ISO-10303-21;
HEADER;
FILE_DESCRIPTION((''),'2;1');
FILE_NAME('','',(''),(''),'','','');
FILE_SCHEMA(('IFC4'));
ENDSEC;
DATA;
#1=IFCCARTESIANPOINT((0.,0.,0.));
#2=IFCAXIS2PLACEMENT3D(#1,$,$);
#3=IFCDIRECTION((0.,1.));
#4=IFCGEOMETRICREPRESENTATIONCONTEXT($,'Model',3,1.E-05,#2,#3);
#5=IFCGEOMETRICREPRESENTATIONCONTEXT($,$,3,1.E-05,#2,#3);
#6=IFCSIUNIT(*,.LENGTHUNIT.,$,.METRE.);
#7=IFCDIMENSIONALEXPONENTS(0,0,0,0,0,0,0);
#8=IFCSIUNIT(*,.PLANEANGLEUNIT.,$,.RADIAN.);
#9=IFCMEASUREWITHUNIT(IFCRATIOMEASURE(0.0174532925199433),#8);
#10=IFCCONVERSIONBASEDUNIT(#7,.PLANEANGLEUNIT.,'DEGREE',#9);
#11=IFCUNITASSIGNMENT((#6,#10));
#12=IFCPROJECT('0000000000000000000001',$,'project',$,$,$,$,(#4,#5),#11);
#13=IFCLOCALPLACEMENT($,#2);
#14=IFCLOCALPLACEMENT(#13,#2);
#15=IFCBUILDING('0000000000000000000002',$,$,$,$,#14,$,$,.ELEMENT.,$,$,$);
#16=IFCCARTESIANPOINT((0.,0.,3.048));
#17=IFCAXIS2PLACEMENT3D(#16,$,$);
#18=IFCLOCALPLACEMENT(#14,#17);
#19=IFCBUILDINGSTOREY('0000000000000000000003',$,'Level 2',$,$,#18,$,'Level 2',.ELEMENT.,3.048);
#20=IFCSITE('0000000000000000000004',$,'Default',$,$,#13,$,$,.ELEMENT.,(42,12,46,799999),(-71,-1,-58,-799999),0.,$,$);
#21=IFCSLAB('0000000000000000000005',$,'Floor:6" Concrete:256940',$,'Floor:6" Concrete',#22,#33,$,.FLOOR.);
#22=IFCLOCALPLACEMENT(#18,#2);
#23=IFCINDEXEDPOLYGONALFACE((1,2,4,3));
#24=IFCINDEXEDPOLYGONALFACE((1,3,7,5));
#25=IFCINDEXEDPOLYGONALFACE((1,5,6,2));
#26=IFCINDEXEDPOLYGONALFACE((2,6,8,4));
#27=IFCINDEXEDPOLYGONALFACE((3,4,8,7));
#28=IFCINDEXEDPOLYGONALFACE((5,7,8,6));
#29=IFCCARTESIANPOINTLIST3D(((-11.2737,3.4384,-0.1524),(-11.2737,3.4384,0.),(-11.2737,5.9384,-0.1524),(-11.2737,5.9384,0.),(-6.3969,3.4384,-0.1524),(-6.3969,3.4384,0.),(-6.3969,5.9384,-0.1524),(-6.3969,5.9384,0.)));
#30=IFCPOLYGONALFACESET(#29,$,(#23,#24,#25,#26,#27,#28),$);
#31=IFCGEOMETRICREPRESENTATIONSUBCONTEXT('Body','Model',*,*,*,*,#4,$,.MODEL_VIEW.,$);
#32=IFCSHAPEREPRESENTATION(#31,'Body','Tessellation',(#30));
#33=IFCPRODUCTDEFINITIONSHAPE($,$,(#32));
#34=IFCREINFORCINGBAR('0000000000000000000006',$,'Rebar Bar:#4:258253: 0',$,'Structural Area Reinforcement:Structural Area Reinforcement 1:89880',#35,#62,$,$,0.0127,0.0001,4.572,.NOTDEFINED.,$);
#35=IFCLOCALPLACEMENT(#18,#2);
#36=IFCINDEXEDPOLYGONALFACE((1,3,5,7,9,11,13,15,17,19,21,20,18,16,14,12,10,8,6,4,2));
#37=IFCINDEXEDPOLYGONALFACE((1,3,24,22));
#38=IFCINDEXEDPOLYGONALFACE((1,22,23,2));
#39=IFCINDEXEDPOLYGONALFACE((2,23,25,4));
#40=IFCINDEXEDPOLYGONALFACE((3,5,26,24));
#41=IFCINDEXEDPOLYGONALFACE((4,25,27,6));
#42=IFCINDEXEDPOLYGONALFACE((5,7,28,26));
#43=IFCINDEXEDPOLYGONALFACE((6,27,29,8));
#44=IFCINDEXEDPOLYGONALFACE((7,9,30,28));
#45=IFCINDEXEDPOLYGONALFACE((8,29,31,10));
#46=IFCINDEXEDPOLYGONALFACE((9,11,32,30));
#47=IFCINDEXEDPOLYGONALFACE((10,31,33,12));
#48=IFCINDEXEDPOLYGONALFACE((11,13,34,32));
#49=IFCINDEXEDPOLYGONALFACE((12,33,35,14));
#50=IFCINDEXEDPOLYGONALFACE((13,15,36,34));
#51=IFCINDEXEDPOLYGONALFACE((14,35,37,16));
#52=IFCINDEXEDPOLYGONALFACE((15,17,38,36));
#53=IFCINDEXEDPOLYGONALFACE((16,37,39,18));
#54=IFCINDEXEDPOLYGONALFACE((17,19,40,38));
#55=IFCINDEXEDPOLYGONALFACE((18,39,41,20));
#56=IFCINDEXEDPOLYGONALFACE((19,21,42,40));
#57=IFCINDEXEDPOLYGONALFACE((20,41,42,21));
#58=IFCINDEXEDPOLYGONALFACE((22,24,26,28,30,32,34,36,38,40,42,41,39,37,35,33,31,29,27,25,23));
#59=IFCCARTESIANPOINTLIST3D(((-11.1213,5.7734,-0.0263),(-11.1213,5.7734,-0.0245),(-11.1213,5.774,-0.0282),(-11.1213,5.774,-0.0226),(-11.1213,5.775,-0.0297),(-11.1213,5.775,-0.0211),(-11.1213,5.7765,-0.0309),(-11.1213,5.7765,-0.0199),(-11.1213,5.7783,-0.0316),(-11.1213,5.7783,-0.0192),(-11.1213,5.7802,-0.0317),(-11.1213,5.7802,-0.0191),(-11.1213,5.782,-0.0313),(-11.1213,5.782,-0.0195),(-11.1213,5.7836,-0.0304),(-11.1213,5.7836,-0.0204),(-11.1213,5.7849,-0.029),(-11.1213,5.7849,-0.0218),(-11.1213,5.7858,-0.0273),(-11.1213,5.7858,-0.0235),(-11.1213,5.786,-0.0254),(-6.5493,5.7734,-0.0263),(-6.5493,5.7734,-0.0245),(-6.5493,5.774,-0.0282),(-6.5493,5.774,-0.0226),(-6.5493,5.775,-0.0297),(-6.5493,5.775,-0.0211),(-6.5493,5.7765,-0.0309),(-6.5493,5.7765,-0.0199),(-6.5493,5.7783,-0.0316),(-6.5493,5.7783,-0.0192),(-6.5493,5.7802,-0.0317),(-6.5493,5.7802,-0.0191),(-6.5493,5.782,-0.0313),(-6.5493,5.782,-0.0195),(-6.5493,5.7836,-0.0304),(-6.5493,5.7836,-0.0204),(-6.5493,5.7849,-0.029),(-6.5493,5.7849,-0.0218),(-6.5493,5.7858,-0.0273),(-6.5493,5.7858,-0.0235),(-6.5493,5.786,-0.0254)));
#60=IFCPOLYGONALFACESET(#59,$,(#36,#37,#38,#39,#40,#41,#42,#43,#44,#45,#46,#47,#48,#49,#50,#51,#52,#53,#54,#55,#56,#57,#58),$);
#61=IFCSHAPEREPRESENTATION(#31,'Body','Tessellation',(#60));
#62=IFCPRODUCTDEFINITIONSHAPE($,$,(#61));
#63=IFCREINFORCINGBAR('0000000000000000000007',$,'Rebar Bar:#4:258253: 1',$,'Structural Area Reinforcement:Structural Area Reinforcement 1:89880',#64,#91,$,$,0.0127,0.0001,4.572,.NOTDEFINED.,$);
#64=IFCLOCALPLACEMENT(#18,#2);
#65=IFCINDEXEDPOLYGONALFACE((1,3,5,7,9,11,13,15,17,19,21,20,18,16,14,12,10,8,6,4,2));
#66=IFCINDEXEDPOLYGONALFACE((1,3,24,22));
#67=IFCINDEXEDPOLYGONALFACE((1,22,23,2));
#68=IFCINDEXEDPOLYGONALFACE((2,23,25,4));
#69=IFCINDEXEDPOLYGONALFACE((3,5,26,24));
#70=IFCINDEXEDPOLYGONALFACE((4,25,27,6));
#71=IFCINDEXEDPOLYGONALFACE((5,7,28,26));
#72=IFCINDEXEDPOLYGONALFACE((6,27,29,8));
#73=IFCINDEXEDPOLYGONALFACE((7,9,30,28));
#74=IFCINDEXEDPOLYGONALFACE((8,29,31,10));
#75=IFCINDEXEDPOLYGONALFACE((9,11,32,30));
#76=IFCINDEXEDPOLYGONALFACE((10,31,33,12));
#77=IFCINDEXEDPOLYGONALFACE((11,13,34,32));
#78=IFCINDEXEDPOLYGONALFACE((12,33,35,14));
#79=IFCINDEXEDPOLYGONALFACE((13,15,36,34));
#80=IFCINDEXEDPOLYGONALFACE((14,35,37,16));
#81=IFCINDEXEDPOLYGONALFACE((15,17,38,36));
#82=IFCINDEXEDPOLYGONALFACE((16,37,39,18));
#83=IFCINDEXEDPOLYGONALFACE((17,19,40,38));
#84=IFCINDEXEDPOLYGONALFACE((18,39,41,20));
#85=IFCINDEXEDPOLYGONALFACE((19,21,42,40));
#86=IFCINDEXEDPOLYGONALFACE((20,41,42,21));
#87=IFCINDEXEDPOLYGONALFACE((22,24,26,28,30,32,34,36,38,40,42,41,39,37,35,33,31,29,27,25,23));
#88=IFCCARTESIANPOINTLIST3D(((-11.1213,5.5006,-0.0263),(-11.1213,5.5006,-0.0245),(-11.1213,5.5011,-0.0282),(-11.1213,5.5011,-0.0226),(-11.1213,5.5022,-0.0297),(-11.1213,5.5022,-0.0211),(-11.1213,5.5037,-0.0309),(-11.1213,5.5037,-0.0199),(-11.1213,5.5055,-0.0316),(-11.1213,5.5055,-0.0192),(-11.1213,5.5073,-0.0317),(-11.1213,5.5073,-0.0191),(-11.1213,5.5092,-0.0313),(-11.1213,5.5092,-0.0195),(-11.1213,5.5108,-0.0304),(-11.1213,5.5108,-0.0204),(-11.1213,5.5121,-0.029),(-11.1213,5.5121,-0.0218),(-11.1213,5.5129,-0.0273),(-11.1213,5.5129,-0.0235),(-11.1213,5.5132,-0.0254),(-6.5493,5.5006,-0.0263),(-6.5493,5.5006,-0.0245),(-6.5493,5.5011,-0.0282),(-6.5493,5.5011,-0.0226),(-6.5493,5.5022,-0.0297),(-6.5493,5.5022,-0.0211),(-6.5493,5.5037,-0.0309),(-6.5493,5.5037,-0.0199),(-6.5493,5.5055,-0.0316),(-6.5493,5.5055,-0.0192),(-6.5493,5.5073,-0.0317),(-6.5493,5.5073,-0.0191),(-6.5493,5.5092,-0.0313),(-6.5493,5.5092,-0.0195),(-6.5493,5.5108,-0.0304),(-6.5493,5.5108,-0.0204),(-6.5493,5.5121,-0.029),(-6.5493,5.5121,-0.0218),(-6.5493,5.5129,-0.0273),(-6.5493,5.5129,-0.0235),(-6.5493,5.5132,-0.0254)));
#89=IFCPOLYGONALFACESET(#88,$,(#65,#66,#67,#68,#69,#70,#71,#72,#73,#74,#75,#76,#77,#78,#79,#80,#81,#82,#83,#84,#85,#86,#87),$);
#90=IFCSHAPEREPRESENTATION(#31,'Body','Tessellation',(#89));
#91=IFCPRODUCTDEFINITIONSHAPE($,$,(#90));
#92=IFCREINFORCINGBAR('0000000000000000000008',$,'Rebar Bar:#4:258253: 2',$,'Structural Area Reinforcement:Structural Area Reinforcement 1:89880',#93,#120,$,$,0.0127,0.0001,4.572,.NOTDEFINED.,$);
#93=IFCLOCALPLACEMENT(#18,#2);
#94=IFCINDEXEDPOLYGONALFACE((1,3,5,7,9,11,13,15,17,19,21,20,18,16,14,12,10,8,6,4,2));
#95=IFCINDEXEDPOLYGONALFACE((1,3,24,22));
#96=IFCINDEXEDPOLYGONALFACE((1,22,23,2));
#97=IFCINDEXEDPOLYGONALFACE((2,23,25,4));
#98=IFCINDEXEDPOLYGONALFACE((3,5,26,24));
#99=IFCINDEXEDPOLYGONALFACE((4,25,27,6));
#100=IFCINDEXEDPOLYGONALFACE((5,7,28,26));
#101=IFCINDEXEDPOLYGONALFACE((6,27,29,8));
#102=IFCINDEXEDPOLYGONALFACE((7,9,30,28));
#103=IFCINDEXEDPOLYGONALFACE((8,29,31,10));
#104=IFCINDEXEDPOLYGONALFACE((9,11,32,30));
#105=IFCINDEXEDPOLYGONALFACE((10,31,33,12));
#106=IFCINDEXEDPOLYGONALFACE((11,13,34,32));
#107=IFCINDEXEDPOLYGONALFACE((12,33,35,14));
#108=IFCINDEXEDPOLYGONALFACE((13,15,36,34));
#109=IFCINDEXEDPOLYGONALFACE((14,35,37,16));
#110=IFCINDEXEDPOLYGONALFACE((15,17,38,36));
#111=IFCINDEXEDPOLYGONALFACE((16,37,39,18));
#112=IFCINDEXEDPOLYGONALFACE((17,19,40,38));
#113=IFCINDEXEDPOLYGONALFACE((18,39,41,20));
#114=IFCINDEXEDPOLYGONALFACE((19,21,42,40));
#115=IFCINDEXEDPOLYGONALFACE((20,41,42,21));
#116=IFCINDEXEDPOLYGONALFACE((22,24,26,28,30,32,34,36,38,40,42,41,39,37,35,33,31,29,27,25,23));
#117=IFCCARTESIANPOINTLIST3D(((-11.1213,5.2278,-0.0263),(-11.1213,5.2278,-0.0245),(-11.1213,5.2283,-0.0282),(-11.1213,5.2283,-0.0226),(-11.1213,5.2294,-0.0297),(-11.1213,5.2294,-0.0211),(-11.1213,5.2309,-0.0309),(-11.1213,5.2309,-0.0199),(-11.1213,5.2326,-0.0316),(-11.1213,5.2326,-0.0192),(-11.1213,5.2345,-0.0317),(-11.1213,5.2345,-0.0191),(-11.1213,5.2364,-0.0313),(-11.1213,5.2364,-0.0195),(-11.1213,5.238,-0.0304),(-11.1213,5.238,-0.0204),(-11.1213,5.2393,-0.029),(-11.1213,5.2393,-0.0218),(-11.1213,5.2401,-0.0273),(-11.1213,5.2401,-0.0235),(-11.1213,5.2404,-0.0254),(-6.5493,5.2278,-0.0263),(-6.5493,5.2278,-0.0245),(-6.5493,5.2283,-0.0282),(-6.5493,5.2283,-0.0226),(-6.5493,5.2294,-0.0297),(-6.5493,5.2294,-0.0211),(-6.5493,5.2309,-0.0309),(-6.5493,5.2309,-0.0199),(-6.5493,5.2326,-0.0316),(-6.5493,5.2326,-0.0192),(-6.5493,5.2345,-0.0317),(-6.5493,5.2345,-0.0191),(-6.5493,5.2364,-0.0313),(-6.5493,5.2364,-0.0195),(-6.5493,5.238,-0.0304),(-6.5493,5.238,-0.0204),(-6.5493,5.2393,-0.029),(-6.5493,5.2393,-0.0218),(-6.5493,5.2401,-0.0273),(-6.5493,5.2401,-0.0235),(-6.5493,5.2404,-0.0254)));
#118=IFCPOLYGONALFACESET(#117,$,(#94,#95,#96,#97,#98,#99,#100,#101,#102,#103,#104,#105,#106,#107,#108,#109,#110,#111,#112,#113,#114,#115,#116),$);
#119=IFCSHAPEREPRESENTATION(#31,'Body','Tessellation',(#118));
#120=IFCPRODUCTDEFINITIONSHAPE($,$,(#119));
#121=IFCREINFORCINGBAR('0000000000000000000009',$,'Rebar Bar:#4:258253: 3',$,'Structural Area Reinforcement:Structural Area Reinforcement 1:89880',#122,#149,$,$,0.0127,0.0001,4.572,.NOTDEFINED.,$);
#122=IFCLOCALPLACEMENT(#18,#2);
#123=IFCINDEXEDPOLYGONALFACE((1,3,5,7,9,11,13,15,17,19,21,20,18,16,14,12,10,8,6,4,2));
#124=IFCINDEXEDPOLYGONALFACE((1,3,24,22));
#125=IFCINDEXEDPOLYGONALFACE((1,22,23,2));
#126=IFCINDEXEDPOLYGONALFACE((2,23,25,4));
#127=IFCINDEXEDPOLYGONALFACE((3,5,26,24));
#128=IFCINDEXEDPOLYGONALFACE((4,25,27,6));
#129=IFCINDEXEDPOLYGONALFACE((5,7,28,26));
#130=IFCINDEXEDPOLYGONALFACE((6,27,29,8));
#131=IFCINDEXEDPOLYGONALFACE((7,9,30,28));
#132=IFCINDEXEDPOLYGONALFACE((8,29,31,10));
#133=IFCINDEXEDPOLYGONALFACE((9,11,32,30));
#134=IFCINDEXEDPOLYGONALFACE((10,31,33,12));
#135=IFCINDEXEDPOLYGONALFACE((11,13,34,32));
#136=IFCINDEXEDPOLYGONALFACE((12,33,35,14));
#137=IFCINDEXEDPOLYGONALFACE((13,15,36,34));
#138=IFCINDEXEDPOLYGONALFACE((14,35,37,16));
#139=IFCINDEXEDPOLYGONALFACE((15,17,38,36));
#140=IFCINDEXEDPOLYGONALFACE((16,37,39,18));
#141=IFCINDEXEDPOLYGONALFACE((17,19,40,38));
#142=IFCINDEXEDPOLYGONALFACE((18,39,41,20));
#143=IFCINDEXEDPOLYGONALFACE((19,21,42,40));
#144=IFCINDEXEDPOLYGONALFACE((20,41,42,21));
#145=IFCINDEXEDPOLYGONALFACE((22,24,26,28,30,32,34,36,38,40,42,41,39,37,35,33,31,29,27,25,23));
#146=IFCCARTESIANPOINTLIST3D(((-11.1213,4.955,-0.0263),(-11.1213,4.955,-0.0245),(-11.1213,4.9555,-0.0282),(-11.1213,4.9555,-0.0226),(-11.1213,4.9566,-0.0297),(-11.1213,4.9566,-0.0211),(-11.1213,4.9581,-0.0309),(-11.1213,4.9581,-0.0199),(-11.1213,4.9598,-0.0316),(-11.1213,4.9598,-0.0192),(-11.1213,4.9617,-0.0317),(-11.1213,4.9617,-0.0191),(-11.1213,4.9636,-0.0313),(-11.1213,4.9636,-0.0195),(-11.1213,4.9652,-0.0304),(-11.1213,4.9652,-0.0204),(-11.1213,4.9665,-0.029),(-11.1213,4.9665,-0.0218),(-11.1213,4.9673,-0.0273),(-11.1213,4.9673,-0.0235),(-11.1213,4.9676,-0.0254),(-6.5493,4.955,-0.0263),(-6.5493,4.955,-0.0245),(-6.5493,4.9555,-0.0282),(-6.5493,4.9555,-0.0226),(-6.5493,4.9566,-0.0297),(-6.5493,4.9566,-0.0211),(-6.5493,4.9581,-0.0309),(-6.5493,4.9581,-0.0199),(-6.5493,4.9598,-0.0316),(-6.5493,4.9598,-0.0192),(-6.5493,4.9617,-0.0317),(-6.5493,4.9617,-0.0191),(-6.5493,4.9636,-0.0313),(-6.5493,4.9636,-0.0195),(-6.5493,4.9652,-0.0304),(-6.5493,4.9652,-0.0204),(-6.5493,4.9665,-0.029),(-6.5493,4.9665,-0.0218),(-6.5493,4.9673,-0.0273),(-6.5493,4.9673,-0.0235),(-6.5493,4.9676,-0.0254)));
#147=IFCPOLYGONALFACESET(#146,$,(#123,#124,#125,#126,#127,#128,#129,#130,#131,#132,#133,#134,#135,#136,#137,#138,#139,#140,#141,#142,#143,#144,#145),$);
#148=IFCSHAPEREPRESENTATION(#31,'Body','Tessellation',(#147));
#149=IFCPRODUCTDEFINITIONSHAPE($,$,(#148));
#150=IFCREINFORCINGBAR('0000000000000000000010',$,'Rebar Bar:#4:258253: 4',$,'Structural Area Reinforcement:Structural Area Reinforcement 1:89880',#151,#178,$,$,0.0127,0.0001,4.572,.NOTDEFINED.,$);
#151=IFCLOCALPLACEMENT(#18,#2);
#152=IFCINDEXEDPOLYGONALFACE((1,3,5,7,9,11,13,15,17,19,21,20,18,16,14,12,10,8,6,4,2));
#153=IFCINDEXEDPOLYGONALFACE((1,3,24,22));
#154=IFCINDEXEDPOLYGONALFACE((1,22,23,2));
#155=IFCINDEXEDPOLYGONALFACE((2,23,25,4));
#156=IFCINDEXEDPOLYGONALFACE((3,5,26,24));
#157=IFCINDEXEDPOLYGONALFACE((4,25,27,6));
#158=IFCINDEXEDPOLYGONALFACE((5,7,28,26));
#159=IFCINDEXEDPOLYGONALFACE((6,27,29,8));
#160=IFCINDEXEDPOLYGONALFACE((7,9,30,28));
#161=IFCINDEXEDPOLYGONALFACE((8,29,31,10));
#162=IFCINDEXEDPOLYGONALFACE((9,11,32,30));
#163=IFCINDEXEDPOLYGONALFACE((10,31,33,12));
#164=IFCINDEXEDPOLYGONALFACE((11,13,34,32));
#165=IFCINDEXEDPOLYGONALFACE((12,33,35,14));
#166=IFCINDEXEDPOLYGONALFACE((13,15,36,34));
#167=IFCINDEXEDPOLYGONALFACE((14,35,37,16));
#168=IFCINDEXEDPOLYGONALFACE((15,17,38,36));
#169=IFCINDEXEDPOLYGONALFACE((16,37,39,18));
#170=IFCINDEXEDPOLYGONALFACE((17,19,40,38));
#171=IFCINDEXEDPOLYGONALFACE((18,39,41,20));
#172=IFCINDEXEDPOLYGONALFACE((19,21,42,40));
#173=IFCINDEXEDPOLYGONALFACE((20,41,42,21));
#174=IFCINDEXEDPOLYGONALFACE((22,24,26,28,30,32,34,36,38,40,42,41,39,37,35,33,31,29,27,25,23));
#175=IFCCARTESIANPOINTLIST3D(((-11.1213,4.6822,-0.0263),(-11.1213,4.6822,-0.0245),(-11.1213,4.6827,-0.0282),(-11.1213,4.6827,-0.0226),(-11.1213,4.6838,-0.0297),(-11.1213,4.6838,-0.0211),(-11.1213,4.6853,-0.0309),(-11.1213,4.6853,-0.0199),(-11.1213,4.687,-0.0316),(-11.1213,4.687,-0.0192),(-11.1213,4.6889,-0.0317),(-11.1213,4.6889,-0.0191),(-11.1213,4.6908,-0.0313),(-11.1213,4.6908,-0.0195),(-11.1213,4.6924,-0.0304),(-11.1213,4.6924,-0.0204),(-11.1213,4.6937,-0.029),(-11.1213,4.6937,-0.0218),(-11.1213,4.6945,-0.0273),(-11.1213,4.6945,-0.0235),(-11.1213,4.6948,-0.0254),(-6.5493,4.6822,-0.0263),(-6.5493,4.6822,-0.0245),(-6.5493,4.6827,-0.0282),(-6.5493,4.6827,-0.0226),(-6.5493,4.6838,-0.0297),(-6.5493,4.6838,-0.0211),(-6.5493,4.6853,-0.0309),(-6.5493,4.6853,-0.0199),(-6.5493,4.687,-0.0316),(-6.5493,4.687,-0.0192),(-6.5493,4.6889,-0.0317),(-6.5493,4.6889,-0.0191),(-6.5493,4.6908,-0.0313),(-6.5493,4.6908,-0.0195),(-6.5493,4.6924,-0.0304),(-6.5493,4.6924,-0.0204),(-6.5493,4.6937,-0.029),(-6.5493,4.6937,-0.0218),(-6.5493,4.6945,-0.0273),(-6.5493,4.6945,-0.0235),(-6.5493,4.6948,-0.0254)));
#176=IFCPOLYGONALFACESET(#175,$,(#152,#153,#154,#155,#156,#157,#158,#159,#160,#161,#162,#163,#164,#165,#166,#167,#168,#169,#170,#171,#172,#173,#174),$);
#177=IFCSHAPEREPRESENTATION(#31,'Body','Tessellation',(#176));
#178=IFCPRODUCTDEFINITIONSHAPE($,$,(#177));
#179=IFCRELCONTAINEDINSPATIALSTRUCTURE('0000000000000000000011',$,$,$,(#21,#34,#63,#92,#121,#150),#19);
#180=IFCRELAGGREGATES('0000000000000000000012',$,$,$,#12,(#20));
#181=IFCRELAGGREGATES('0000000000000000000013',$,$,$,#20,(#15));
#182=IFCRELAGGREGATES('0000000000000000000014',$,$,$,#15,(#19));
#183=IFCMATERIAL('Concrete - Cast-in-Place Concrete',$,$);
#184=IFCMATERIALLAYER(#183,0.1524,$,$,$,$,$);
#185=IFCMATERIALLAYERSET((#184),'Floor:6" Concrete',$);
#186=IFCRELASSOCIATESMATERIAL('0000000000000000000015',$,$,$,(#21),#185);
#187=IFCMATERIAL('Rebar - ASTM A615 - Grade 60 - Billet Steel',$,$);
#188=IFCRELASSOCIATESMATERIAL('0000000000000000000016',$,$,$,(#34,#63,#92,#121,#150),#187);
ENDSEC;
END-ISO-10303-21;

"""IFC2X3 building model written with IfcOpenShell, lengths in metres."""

from ifc_helpers import new_model, entity, si_unit, converted_unit, direction, frame, frame_2d, origin, place, context, subcontext, project, spatial, rectangle, extrude, material, layer, layer_set, layer_usage, element, save


model = new_model("IFC2X3")

# Units and contexts
model_context = context("Model", 3, precision=1e-05, world=origin(), true_north=direction((0.0, 1.0)))
context_of_model = context(None, 3, precision=1e-05, world=origin(), true_north=direction((0.0, 1.0)))
body_context = subcontext(model_context, "Body", "Model", "MODEL_VIEW")
ifc_project = project(units=[si_unit("LENGTHUNIT", "METRE"), converted_unit("PLANEANGLEUNIT", "DEGREE", entity("IfcRatioMeasure", 0.0174532925199433), si_unit("PLANEANGLEUNIT", "RADIAN"), dimensions=[0, 0, 0, 0, 0, 0, 0])], contexts=[model_context, context_of_model])

# Site, building, storey
site_placement = place(None, origin())
site = spatial("IfcSite", under=ifc_project, at=site_placement, Name="Default", CompositionType="ELEMENT", RefLatitude=(42, 12, 46, 799999), RefLongitude=(-71, -1, -58, -799999), RefElevation=0.0)
building_placement = place(site_placement, origin())
building = spatial("IfcBuilding", under=site, at=building_placement, CompositionType="ELEMENT")
storey_placement = place(building_placement, frame((0.0, 0.0, 3.048)))
storey = spatial("IfcBuildingStorey", under=building, at=storey_placement, Name="Level 2", LongName="Level 2", CompositionType="ELEMENT", Elevation=3.048)

# Shared definitions
ifc_material_1 = material(Name="Concrete - Cast-in-Place Concrete")

# Slab
ifc_layer = layer(ifc_material_1, 0.1524)
ifc_layer_set = layer_set([ifc_layer], Name="Floor:6\" Concrete")
ifc_layer_usage = layer_usage(ifc_layer_set, "AXIS3", "POSITIVE", 0.0)
slab_placement = place(storey_placement, origin())
element("IfcSlab", 1, at=slab_placement, inside=storey, material=ifc_layer_usage, Name="Floor:6\" Concrete:256940", ObjectType="Floor:6\" Concrete", PredefinedType="FLOOR", context=body_context, shape_type="SweptSolid", body=[
    extrude(rectangle(XDim=2.5, YDim=4.8768, at=frame_2d((0.0, 0.0), x_axis=(1.0, 0.0))), frame((-8.8353, 4.6884, 0.0), z_axis=(0.0, 0.0, -1.0), x_axis=(0.0, 1.0, 0.0)), (0.0, 0.0, 1.0), 0.1524),
])

# Reinforcing bars
ifc_material_2 = material(Name="Rebar - ASTM A615 - Grade 60 - Billet Steel")
reinforcing_bar_1_placement = place(storey_placement, origin())
element("IfcReinforcingBar", 2, at=reinforcing_bar_1_placement, inside=storey, material=ifc_material_2, Name="Rebar Bar:#4:258253: 0", ObjectType="Structural Area Reinforcement:Structural Area Reinforcement 1:89880", BarLength=4.572, BarRole="NOTDEFINED", CrossSectionArea=0.0001, NominalDiameter=0.0127, context=body_context, shape_type="AdvancedSweptSolid", body=[
    entity("IfcSweptDiskSolid", entity("IfcCompositeCurve", [entity("IfcCompositeCurveSegment", "CONTINUOUS", True, entity("IfcPolyline", [entity("IfcCartesianPoint", [-11.1213, 5.7797, -0.0254]), entity("IfcCartesianPoint", [-6.5493, 5.7797, -0.0254])]))], False), 0.0063, None, 0.0, 1.0),
])
reinforcing_bar_2_placement = place(storey_placement, origin())
element("IfcReinforcingBar", 3, at=reinforcing_bar_2_placement, inside=storey, material=ifc_material_2, Name="Rebar Bar:#4:258253: 1", ObjectType="Structural Area Reinforcement:Structural Area Reinforcement 1:89880", BarLength=4.572, BarRole="NOTDEFINED", CrossSectionArea=0.0001, NominalDiameter=0.0127, context=body_context, shape_type="AdvancedSweptSolid", body=[
    entity("IfcSweptDiskSolid", entity("IfcCompositeCurve", [entity("IfcCompositeCurveSegment", "CONTINUOUS", True, entity("IfcPolyline", [entity("IfcCartesianPoint", [-11.1213, 5.5069, -0.0254]), entity("IfcCartesianPoint", [-6.5493, 5.5069, -0.0254])]))], False), 0.0063, None, 0.0, 1.0),
])
reinforcing_bar_3_placement = place(storey_placement, origin())
element("IfcReinforcingBar", 4, at=reinforcing_bar_3_placement, inside=storey, material=ifc_material_2, Name="Rebar Bar:#4:258253: 2", ObjectType="Structural Area Reinforcement:Structural Area Reinforcement 1:89880", BarLength=4.572, BarRole="NOTDEFINED", CrossSectionArea=0.0001, NominalDiameter=0.0127, context=body_context, shape_type="AdvancedSweptSolid", body=[
    entity("IfcSweptDiskSolid", entity("IfcCompositeCurve", [entity("IfcCompositeCurveSegment", "CONTINUOUS", True, entity("IfcPolyline", [entity("IfcCartesianPoint", [-11.1213, 5.2341, -0.0254]), entity("IfcCartesianPoint", [-6.5493, 5.2341, -0.0254])]))], False), 0.0063, None, 0.0, 1.0),
])
reinforcing_bar_4_placement = place(storey_placement, origin())
element("IfcReinforcingBar", 5, at=reinforcing_bar_4_placement, inside=storey, material=ifc_material_2, Name="Rebar Bar:#4:258253: 3", ObjectType="Structural Area Reinforcement:Structural Area Reinforcement 1:89880", BarLength=4.572, BarRole="NOTDEFINED", CrossSectionArea=0.0001, NominalDiameter=0.0127, context=body_context, shape_type="AdvancedSweptSolid", body=[
    entity("IfcSweptDiskSolid", entity("IfcCompositeCurve", [entity("IfcCompositeCurveSegment", "CONTINUOUS", True, entity("IfcPolyline", [entity("IfcCartesianPoint", [-11.1213, 4.9612, -0.0254]), entity("IfcCartesianPoint", [-6.5493, 4.9612, -0.0254])]))], False), 0.0063, None, 0.0, 1.0),
])
reinforcing_bar_5_placement = place(storey_placement, origin())
element("IfcReinforcingBar", 6, at=reinforcing_bar_5_placement, inside=storey, material=ifc_material_2, Name="Rebar Bar:#4:258253: 4", ObjectType="Structural Area Reinforcement:Structural Area Reinforcement 1:89880", BarLength=4.572, BarRole="NOTDEFINED", CrossSectionArea=0.0001, NominalDiameter=0.0127, context=body_context, shape_type="AdvancedSweptSolid", body=[
    entity("IfcSweptDiskSolid", entity("IfcCompositeCurve", [entity("IfcCompositeCurveSegment", "CONTINUOUS", True, entity("IfcPolyline", [entity("IfcCartesianPoint", [-11.1213, 4.6884, -0.0254]), entity("IfcCartesianPoint", [-6.5493, 4.6884, -0.0254])]))], False), 0.0063, None, 0.0, 1.0),
])

save(model, "model.ifc")
